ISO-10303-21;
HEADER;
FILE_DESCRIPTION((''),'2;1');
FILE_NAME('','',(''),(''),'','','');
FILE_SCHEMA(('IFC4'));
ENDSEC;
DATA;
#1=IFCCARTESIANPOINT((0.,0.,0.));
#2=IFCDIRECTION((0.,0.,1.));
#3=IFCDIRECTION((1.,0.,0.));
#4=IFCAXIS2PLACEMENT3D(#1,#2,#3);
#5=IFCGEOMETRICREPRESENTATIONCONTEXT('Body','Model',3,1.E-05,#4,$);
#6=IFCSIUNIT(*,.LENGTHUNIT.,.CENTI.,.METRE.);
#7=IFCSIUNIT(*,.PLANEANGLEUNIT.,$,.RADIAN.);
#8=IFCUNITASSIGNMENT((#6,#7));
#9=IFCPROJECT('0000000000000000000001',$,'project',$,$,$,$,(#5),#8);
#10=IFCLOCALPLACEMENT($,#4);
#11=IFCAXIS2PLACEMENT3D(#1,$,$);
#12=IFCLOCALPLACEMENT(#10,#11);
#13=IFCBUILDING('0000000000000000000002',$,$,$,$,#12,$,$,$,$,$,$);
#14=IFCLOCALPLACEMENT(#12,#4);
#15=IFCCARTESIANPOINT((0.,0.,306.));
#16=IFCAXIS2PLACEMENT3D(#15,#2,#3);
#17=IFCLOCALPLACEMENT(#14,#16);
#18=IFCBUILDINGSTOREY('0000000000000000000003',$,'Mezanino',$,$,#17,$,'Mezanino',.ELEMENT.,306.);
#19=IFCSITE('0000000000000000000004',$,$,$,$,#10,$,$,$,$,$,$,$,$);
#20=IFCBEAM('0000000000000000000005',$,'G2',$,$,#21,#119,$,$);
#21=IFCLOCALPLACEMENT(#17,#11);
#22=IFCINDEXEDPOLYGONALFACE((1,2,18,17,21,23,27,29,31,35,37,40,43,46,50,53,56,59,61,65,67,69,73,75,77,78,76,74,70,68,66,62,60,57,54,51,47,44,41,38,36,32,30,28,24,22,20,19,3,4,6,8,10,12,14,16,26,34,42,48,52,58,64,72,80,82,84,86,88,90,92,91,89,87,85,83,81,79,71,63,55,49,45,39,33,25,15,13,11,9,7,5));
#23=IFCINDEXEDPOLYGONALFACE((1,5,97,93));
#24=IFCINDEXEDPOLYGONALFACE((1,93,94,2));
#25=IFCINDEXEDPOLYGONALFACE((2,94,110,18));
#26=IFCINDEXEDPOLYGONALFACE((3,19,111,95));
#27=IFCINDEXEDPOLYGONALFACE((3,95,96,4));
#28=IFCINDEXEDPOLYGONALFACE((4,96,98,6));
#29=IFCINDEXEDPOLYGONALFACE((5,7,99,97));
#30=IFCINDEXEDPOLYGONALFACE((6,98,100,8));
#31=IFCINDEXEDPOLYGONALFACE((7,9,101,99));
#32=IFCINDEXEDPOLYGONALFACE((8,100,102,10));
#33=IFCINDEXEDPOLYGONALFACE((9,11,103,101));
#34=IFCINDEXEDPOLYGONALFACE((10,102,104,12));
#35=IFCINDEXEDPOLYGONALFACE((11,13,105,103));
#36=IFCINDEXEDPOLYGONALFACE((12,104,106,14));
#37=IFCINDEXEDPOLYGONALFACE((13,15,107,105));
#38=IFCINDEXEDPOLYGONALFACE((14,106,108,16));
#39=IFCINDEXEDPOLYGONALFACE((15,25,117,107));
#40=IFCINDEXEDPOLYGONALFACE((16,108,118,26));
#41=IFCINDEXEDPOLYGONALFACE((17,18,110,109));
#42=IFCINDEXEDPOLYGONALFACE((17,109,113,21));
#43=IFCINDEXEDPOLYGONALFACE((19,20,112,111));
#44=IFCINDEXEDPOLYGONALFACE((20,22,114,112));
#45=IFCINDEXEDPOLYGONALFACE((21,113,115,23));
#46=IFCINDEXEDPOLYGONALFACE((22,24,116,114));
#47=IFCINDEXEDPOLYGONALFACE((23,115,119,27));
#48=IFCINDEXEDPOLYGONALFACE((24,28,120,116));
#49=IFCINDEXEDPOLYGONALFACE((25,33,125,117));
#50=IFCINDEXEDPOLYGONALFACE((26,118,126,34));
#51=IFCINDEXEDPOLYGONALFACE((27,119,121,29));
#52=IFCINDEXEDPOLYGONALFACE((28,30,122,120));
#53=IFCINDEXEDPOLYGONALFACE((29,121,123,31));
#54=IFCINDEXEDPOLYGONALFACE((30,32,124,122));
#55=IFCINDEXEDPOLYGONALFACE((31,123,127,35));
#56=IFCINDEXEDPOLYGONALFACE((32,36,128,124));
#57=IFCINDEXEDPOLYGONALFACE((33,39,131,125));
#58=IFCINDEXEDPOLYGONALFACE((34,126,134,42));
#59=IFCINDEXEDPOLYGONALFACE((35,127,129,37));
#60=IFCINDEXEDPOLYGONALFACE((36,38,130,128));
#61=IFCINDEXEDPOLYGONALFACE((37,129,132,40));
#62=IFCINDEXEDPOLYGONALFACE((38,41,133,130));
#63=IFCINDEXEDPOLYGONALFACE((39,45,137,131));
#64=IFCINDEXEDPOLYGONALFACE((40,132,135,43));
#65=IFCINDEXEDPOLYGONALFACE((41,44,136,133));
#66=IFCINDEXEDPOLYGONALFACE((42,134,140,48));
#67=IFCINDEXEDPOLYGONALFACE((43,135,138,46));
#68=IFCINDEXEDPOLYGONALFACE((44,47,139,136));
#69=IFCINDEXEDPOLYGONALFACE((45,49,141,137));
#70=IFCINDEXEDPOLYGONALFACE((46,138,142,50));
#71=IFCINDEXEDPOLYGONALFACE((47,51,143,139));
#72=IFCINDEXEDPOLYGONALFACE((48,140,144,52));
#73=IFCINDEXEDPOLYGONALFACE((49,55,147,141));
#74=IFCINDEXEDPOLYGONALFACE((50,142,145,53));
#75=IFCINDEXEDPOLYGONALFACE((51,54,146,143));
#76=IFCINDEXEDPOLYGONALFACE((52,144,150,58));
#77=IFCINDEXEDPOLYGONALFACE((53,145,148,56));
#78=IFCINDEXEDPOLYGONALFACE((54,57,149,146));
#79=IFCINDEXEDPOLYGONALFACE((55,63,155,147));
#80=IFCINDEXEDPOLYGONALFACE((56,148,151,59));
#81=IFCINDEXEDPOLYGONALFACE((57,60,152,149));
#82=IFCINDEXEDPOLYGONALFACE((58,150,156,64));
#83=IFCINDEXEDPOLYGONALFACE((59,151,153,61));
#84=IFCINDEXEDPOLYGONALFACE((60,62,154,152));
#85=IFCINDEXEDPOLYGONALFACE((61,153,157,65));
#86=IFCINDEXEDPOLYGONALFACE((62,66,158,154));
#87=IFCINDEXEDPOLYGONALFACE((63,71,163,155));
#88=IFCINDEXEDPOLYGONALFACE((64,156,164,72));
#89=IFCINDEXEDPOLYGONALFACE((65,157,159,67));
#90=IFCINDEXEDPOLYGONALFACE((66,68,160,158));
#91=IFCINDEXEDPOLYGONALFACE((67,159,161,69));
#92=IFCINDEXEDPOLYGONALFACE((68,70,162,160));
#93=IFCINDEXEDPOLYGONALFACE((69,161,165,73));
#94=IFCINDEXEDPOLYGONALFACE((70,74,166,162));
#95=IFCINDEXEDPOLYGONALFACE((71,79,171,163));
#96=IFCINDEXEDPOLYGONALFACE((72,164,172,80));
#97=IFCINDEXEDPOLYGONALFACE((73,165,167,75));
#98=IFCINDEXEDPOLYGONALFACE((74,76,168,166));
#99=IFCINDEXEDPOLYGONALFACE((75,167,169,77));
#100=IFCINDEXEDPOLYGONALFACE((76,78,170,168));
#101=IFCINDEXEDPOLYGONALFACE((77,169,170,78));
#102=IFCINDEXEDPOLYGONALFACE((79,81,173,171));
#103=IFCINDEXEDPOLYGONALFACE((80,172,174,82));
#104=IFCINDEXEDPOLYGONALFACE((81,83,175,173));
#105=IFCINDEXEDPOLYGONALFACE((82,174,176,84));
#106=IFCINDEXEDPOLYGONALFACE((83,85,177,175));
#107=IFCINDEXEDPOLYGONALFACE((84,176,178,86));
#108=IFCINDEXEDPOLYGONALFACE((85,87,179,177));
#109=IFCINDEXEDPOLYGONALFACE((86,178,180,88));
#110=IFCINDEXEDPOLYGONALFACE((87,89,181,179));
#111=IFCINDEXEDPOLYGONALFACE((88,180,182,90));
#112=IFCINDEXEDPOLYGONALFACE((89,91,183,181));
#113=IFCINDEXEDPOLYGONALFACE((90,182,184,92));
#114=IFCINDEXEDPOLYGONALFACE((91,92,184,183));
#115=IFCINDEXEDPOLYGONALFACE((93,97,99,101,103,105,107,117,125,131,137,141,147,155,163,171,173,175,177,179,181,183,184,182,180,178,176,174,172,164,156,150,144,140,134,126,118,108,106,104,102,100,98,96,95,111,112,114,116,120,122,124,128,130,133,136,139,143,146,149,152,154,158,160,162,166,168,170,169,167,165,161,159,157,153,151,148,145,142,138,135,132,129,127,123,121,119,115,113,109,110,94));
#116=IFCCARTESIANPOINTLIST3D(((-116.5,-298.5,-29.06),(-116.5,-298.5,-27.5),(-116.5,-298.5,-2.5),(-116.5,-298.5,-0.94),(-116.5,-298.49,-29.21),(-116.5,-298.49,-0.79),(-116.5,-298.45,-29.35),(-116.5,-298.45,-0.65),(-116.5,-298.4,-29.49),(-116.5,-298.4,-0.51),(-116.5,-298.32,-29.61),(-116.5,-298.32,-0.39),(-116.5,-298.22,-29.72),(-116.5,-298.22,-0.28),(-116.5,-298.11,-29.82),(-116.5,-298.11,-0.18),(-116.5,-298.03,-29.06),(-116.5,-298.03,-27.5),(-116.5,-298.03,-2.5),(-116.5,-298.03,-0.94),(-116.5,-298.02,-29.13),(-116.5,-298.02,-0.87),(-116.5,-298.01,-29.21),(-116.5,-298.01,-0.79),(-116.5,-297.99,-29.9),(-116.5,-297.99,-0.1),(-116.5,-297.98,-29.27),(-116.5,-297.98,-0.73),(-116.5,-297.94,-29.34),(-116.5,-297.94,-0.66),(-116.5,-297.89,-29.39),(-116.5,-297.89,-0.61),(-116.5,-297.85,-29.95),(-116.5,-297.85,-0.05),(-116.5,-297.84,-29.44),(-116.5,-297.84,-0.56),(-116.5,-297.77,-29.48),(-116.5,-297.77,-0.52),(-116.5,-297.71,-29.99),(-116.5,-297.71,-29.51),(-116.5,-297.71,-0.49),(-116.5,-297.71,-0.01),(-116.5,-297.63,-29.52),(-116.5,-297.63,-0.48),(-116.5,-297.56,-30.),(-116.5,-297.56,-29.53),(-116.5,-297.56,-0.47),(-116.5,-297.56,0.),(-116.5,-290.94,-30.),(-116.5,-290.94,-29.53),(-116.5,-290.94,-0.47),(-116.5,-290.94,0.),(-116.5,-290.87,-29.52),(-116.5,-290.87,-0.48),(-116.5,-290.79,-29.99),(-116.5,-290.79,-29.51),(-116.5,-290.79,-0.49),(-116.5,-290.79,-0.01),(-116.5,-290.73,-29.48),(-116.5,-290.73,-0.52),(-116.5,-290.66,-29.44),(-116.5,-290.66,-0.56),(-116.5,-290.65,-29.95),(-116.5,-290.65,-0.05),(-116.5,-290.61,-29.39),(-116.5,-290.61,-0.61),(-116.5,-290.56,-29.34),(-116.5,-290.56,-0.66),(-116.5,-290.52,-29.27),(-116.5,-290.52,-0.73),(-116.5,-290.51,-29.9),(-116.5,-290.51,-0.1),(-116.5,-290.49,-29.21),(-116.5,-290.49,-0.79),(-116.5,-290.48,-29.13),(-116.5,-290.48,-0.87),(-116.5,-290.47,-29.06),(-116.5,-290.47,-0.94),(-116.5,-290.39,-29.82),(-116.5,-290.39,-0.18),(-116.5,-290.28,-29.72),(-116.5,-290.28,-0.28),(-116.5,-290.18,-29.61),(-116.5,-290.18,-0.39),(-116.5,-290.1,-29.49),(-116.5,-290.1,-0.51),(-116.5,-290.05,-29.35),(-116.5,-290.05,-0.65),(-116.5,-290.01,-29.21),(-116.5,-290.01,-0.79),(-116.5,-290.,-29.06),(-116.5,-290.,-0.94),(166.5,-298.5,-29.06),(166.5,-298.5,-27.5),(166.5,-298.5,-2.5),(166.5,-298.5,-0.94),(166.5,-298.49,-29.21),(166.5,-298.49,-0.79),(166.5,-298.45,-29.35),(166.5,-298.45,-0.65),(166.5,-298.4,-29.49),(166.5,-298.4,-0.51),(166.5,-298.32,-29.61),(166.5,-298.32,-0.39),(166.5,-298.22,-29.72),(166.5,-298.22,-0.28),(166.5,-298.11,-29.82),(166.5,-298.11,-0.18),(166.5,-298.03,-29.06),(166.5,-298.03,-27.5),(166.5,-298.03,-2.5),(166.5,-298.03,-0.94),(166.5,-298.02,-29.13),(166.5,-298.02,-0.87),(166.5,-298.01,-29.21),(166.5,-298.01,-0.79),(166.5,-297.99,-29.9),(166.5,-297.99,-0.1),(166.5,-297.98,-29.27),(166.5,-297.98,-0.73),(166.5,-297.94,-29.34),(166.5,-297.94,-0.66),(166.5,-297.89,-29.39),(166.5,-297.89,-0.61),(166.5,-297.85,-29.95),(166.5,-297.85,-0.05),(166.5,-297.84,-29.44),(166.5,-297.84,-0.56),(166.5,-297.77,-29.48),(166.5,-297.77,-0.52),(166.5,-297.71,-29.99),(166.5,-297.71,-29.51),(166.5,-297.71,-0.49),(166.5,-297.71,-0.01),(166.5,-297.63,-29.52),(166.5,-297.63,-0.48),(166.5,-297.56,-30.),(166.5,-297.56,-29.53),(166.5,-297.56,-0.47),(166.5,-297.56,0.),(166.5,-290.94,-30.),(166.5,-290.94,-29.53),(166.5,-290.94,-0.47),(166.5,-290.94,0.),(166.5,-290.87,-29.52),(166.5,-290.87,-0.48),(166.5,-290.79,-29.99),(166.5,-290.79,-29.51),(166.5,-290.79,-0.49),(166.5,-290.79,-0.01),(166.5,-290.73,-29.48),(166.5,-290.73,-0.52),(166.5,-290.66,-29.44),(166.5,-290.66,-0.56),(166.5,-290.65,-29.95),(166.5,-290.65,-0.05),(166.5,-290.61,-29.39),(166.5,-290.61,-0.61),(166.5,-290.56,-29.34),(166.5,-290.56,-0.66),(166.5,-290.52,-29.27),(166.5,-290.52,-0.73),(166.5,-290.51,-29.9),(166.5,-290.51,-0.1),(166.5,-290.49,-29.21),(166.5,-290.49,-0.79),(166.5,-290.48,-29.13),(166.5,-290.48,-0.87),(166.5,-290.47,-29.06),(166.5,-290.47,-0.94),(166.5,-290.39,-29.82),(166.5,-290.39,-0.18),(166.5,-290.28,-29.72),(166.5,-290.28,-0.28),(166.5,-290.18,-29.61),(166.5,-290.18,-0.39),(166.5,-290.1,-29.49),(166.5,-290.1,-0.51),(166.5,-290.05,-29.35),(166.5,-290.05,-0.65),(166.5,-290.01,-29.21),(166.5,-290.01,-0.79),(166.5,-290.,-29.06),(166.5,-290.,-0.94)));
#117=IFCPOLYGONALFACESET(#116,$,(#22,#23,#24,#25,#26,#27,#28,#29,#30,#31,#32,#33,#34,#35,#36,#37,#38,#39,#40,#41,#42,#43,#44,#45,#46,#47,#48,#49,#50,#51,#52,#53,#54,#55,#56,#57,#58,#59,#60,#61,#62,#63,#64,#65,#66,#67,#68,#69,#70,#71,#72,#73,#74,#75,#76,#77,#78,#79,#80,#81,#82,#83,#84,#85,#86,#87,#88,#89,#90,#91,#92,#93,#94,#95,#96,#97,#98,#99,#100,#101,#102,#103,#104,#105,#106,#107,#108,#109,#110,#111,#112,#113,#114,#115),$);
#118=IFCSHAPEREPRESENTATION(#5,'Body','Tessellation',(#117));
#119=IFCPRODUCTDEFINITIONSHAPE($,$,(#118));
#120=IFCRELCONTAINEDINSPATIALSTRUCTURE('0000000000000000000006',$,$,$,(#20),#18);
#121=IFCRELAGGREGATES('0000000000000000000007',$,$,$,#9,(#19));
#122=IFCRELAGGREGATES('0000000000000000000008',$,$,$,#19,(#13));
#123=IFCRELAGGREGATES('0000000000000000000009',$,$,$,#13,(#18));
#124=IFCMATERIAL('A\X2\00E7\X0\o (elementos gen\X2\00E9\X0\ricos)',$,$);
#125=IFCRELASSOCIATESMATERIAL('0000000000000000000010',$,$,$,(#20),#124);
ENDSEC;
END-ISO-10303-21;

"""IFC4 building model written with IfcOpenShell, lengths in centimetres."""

from ifc_helpers import new_model, si_unit, frame, origin, origin_with_axes, place, context, project, spatial, polyline, outline, extrude, material, element, save


model = new_model("IFC4")

# Units and contexts
model_context = context("Model", 3, precision=1e-05, world=origin_with_axes(), identifier="Body")
ifc_project = project(units=[si_unit("LENGTHUNIT", "METRE", prefix="CENTI"), si_unit("PLANEANGLEUNIT", "RADIAN")], contexts=[model_context])

# Site, building, storey
site_placement = place(None, origin_with_axes())
site = spatial("IfcSite", under=ifc_project, at=site_placement)
building_placement = place(site_placement, origin())
building = spatial("IfcBuilding", under=site, at=building_placement)
placement = place(building_placement, origin_with_axes())
storey_placement = place(placement, frame((0.0, 0.0, 306.0), z_axis=(0.0, 0.0, 1.0), x_axis=(1.0, 0.0, 0.0)))
storey = spatial("IfcBuildingStorey", under=building, at=storey_placement, Name="Mezanino", LongName="Mezanino", CompositionType="ELEMENT", Elevation=306.0)

# Beam
ifc_material_1 = material(Name="Aço (elementos genéricos)")
beam_1_placement = place(storey_placement, frame((25.0, -294.25, 0.0), z_axis=(0.0, 0.0, 1.0), x_axis=(1.0, 0.0, 0.0)))
element("IfcBeam", 1, at=beam_1_placement, inside=storey, material=ifc_material_1, Name="G2", context=model_context, shape_type="SolidModel", body=[
    extrude(outline(polyline([(-4.25, -14.06), (-4.24, -14.21), (-4.2, -14.35), (-4.15, -14.49), (-4.07, -14.61), (-3.97, -14.72), (-3.86, -14.82), (-3.74, -14.9), (-3.6, -14.95), (-3.46, -14.99), (-3.31, -15.0), (3.31, -15.0), (3.46, -14.99), (3.6, -14.95), (3.74, -14.9), (3.86, -14.82), (3.97, -14.72), (4.07, -14.61), (4.15, -14.49), (4.2, -14.35), (4.24, -14.21), (4.25, -14.06), (4.25, -12.5), (3.78, -12.5), (3.78, -14.06), (3.77, -14.13), (3.76, -14.21), (3.73, -14.27), (3.69, -14.34), (3.64, -14.39), (3.59, -14.44), (3.52, -14.48), (3.46, -14.51), (3.38, -14.52), (3.31, -14.53), (-3.31, -14.53), (-3.38, -14.52), (-3.46, -14.51), (-3.52, -14.48), (-3.59, -14.44), (-3.64, -14.39), (-3.69, -14.34), (-3.73, -14.27), (-3.76, -14.21), (-3.77, -14.13), (-3.78, -14.06), (-3.78, 14.06), (-3.77, 14.13), (-3.76, 14.21), (-3.73, 14.27), (-3.69, 14.34), (-3.64, 14.39), (-3.59, 14.44), (-3.52, 14.48), (-3.46, 14.51), (-3.38, 14.52), (-3.31, 14.53), (3.31, 14.53), (3.38, 14.52), (3.46, 14.51), (3.52, 14.48), (3.59, 14.44), (3.64, 14.39), (3.69, 14.34), (3.73, 14.27), (3.76, 14.21), (3.77, 14.13), (3.78, 14.06), (3.78, 12.5), (4.25, 12.5), (4.25, 14.06), (4.24, 14.21), (4.2, 14.35), (4.15, 14.49), (4.07, 14.61), (3.97, 14.72), (3.86, 14.82), (3.74, 14.9), (3.6, 14.95), (3.46, 14.99), (3.31, 15.0), (-3.31, 15.0), (-3.46, 14.99), (-3.6, 14.95), (-3.74, 14.9), (-3.86, 14.82), (-3.97, 14.72), (-4.07, 14.61), (-4.15, 14.49), (-4.2, 14.35), (-4.24, 14.21), (-4.25, 14.06), (-4.25, -14.06)])), frame((-141.5, 0.0, -15.0), z_axis=(1.0, 0.0, 0.0), x_axis=(0.0, -1.0, 0.0)), (0.0, 0.0, 1.0), 283.0),
])

save(model, "model.ifc")
